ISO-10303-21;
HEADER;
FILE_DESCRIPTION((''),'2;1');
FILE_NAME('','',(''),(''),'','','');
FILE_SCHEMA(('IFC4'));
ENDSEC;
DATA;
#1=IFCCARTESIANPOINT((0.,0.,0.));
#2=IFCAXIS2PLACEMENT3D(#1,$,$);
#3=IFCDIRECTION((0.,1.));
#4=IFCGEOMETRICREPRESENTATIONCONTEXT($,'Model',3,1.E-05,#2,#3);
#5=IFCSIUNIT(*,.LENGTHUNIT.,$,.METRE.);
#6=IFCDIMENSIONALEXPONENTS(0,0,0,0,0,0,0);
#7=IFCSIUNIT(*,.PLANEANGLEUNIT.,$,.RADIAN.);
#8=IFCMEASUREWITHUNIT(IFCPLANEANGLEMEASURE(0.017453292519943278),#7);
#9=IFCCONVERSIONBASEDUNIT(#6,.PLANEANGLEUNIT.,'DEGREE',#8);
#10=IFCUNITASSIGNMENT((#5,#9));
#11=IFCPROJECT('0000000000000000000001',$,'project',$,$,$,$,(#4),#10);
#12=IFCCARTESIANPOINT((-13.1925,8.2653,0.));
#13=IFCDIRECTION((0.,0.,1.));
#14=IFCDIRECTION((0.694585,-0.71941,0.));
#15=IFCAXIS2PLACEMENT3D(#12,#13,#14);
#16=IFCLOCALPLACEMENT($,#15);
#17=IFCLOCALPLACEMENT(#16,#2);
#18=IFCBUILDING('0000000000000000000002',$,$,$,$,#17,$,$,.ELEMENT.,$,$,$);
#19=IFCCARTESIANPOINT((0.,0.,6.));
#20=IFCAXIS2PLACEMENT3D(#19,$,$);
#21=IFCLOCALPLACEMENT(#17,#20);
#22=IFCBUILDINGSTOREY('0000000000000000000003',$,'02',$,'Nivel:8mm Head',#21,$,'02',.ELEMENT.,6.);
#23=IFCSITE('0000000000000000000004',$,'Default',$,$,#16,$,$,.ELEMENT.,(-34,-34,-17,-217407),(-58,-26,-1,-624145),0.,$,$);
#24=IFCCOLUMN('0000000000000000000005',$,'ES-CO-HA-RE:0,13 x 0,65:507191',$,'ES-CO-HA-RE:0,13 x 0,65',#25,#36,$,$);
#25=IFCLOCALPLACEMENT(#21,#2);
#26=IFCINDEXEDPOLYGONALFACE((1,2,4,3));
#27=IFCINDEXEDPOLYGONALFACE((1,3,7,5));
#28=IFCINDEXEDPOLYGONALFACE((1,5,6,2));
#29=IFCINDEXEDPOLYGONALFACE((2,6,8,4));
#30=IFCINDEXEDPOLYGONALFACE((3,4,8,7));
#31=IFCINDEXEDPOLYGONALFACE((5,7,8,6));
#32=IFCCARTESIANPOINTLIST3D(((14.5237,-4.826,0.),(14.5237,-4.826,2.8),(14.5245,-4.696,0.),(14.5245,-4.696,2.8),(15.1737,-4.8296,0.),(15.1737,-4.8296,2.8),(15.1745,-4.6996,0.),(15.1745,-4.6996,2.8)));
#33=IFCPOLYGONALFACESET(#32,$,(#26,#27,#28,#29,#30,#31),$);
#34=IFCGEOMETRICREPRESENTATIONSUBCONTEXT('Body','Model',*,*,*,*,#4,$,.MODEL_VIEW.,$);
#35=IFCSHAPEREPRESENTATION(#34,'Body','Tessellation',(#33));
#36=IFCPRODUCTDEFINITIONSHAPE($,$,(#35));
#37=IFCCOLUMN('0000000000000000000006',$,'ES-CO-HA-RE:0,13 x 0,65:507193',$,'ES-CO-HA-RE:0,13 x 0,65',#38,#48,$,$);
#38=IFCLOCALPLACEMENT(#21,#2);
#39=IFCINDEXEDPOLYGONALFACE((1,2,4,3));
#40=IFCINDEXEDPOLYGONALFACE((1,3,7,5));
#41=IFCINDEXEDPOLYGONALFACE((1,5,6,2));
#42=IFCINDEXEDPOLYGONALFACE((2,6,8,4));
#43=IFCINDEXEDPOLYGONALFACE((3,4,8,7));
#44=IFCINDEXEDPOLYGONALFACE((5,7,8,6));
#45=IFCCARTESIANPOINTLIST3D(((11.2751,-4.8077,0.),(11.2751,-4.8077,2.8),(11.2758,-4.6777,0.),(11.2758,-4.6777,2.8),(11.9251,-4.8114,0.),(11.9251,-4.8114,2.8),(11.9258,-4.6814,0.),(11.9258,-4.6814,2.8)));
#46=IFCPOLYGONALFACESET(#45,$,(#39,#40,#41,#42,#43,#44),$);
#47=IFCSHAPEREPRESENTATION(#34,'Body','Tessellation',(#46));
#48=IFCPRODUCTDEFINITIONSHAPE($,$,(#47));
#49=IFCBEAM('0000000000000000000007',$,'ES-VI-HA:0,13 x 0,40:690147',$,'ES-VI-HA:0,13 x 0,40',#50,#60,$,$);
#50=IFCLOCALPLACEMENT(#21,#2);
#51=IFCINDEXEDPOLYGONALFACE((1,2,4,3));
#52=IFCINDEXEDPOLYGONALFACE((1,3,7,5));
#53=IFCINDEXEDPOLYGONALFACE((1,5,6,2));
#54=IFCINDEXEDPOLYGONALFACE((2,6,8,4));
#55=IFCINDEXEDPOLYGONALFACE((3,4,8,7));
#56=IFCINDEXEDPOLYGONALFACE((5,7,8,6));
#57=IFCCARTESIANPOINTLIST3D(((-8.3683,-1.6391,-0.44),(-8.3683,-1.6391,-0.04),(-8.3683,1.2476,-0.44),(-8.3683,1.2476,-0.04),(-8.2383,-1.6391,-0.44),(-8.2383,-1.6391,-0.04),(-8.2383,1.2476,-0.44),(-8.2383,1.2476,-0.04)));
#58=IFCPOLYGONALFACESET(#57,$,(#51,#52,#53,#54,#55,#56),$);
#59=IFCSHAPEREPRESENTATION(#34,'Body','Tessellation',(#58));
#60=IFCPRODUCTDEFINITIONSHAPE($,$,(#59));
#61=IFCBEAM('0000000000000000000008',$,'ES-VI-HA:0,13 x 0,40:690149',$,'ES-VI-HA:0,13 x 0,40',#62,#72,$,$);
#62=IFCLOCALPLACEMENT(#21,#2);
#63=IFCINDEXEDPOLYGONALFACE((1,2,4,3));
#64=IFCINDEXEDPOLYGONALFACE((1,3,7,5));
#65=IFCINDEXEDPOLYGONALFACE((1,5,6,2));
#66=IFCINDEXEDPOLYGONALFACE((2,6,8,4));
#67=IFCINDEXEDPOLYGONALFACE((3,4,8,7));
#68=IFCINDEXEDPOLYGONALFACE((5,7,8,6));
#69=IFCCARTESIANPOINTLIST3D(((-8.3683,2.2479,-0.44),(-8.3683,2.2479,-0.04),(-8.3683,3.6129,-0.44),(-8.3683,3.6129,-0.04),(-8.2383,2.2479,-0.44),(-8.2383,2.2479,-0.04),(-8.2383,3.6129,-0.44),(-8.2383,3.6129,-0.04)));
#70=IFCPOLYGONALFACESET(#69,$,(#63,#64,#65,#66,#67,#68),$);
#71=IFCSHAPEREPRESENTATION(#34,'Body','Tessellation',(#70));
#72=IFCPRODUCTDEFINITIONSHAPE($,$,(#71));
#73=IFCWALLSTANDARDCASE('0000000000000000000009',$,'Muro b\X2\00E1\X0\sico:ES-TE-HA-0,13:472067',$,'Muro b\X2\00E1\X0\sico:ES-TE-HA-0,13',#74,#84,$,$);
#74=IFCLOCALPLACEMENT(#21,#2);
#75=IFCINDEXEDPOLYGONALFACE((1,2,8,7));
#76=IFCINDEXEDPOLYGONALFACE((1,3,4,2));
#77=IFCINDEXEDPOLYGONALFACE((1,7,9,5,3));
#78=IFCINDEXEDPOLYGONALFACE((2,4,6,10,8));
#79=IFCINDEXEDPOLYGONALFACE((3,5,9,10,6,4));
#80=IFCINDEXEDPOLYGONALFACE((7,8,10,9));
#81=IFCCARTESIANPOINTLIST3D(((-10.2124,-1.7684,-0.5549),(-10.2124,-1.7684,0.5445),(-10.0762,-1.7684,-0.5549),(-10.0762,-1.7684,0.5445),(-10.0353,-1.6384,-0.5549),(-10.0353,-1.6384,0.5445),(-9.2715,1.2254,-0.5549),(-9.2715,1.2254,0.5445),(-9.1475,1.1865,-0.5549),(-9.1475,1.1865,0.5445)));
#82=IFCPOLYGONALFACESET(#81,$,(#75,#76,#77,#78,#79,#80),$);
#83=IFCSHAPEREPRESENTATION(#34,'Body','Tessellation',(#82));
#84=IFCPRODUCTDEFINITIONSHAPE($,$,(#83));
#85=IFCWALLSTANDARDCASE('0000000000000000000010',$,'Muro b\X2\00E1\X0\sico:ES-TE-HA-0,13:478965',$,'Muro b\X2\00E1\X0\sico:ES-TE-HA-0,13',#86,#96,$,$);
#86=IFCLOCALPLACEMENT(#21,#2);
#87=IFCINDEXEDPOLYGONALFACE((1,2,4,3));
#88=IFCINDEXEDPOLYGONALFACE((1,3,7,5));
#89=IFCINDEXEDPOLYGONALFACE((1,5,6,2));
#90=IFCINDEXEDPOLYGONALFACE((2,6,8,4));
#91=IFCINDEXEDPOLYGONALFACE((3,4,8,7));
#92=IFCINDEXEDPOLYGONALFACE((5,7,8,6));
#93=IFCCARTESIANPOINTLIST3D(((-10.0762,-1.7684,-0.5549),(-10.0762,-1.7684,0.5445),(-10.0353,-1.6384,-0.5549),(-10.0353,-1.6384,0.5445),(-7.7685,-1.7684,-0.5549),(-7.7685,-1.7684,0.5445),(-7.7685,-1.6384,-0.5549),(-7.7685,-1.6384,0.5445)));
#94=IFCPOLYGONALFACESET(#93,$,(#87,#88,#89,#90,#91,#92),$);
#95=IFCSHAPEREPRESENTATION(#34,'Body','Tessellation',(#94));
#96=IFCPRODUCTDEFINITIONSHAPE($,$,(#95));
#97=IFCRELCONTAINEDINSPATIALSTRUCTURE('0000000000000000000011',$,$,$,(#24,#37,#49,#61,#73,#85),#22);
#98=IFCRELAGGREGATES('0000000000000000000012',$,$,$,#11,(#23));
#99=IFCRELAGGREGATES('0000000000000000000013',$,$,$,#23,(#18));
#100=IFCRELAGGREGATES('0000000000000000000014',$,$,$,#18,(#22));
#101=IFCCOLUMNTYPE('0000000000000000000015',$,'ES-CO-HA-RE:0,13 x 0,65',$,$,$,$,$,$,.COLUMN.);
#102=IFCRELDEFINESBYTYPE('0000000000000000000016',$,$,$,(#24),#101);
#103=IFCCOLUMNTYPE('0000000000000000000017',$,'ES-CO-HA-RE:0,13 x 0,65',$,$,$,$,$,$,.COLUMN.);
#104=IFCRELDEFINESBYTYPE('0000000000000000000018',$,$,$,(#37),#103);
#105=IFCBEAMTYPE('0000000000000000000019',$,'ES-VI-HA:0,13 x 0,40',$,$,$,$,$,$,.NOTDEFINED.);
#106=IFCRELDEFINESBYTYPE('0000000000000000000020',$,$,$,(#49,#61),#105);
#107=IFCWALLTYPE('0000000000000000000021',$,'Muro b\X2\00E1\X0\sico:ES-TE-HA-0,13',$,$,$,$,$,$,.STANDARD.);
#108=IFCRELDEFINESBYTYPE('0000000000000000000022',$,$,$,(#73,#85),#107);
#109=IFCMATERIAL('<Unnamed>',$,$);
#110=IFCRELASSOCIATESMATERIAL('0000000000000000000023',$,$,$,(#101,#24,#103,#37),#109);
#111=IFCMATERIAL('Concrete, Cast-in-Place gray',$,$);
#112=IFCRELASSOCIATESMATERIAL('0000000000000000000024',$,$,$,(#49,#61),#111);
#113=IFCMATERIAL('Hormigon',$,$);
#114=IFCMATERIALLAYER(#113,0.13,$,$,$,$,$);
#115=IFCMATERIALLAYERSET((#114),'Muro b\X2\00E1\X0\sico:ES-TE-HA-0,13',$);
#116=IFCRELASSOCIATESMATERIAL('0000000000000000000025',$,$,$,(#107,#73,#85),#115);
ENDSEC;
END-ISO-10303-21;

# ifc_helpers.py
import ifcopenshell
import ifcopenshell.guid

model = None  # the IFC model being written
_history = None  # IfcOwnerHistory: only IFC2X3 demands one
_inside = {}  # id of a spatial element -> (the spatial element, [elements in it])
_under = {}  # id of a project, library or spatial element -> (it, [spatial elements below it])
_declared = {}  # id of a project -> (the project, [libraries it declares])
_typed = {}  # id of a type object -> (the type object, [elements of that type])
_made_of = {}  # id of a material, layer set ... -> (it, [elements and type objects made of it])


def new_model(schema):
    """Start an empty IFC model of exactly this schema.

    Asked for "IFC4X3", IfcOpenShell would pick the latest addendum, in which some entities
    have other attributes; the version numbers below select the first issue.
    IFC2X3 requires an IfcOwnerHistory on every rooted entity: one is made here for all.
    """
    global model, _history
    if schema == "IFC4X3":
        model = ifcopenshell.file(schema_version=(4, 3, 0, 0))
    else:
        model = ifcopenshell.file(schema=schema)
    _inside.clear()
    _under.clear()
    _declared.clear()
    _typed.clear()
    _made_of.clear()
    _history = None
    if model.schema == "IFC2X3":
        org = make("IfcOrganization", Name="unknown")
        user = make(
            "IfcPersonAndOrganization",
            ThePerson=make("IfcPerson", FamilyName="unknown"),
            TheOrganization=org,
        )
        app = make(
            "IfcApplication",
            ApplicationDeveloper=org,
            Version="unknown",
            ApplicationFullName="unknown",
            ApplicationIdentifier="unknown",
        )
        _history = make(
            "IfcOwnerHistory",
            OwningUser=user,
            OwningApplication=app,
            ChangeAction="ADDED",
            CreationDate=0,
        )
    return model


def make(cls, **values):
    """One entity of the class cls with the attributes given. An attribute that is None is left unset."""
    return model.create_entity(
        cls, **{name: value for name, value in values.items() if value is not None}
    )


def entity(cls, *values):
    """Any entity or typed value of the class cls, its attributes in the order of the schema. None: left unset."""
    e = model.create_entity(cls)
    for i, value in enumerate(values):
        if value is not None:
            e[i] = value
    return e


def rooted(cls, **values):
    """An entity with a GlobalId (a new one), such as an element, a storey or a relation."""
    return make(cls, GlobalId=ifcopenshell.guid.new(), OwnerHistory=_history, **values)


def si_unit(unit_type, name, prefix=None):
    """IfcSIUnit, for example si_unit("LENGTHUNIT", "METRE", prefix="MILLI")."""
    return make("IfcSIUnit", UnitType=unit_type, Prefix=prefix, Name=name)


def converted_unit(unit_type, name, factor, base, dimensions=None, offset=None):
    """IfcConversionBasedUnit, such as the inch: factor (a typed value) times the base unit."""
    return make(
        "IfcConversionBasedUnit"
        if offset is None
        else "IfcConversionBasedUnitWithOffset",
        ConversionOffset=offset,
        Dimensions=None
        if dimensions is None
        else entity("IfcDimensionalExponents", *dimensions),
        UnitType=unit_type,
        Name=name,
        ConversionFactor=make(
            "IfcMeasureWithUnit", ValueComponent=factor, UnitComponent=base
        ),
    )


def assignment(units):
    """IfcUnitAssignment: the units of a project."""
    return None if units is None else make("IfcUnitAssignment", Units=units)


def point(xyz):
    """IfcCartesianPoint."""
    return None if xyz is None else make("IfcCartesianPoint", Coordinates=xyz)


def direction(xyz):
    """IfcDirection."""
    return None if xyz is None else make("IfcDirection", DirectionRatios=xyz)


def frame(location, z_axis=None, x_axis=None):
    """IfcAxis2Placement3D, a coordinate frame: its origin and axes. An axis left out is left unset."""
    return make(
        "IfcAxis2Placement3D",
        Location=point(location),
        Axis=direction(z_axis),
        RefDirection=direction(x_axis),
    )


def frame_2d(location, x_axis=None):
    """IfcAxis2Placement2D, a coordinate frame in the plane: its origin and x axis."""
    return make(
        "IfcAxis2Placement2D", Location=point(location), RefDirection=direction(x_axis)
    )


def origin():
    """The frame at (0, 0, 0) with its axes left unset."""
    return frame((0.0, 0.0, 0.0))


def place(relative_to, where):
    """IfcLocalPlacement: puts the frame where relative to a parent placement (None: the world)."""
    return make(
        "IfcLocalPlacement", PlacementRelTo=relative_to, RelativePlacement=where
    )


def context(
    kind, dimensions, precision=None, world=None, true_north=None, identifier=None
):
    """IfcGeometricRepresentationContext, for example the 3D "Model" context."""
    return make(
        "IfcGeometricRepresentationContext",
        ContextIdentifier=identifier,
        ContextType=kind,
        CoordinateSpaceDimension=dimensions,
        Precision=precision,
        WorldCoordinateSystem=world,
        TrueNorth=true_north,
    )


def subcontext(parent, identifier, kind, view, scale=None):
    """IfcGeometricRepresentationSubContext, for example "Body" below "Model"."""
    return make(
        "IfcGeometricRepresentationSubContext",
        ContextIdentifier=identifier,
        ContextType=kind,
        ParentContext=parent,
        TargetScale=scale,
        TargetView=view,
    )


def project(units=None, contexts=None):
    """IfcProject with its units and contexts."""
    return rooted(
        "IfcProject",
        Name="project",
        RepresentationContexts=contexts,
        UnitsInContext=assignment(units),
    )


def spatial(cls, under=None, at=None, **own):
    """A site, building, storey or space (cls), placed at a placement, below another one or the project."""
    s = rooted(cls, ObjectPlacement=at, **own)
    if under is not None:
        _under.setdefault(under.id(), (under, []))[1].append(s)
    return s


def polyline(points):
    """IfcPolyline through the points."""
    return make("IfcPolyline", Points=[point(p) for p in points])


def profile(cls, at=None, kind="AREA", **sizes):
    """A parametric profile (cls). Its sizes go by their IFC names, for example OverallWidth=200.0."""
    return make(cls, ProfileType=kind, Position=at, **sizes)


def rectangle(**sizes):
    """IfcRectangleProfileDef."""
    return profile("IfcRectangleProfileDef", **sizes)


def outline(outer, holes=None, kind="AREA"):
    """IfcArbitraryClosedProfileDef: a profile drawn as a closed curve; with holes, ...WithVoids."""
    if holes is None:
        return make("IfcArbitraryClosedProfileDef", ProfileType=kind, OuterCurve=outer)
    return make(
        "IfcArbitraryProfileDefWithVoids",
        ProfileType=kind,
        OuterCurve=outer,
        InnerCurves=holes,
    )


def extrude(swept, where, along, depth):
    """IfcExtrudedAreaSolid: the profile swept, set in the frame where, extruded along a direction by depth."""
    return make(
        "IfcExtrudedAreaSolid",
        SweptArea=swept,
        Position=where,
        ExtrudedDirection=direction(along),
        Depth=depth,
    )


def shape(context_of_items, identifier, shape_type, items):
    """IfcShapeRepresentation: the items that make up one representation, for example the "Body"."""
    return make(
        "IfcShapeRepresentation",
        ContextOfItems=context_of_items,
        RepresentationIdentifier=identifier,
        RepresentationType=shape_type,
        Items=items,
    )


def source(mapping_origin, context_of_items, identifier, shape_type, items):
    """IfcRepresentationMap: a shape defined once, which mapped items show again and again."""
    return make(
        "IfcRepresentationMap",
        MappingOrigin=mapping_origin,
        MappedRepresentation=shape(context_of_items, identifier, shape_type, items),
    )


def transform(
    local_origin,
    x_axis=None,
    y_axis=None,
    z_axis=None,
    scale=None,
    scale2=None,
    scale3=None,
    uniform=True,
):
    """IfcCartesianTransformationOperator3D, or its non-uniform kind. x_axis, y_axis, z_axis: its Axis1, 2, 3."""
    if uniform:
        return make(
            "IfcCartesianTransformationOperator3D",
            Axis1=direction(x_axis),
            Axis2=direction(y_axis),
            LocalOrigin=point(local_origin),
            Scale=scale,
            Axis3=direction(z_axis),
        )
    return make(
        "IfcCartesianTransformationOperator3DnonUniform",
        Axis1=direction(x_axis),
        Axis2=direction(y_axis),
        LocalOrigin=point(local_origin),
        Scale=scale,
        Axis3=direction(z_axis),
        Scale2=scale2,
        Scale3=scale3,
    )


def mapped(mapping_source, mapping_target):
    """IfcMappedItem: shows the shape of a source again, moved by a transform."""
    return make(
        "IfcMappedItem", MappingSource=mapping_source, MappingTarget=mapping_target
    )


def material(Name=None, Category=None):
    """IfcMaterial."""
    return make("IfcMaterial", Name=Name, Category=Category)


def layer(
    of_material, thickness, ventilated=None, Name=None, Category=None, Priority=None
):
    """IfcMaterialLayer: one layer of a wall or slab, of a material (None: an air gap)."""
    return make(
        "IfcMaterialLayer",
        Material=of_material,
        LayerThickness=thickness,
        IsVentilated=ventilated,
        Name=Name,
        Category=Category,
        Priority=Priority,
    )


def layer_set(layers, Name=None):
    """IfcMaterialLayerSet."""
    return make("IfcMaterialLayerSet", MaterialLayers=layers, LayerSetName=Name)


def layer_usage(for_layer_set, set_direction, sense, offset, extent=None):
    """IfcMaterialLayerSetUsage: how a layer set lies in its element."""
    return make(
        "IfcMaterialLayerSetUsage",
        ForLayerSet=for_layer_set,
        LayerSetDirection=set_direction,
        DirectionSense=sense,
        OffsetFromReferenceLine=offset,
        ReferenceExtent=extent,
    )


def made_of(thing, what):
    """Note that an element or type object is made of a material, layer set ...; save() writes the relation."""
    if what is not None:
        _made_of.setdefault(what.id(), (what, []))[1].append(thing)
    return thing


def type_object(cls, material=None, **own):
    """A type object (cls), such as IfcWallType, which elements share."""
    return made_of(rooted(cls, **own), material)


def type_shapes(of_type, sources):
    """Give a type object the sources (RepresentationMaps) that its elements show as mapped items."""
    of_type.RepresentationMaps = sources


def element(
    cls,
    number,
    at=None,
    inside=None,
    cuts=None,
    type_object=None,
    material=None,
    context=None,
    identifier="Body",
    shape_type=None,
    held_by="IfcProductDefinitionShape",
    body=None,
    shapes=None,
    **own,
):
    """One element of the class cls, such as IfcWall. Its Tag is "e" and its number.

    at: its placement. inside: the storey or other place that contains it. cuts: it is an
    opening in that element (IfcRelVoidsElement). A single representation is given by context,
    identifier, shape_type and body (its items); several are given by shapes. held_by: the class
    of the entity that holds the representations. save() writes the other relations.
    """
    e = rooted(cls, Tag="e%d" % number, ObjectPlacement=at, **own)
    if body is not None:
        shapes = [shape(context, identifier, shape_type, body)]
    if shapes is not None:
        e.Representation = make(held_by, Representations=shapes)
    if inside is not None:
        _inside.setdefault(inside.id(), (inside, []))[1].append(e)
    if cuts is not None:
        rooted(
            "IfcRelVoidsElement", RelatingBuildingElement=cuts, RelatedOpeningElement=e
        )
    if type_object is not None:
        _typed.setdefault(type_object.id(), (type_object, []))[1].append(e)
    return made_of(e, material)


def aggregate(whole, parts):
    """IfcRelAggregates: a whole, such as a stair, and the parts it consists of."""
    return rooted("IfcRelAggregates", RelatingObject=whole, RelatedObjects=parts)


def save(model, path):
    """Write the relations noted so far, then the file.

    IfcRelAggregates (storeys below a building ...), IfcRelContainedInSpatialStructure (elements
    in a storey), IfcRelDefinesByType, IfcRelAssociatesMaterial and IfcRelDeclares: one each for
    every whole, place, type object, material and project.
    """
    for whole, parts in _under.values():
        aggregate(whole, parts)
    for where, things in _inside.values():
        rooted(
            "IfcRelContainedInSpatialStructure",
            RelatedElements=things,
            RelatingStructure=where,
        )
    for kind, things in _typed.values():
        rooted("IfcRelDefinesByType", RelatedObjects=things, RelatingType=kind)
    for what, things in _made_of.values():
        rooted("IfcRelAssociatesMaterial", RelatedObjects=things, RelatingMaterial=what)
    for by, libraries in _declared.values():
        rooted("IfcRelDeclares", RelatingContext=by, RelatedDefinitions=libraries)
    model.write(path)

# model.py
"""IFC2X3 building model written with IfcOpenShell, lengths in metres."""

from ifc_helpers import new_model, entity, si_unit, converted_unit, direction, frame, frame_2d, origin, place, context, subcontext, project, spatial, polyline, rectangle, outline, extrude, source, transform, mapped, material, layer, layer_set, layer_usage, type_object, type_shapes, element, save


model = new_model("IFC2X3")

# Units and contexts
model_context = context("Model", 3, precision=1e-05, world=origin(), true_north=direction((0.0, 1.0)))
body_context = subcontext(model_context, "Body", "Model", "MODEL_VIEW")
ifc_project = project(units=[si_unit("LENGTHUNIT", "METRE"), converted_unit("PLANEANGLEUNIT", "DEGREE", entity("IfcPlaneAngleMeasure", 0.017453292519943278), si_unit("PLANEANGLEUNIT", "RADIAN"), dimensions=[0, 0, 0, 0, 0, 0, 0])], contexts=[model_context])

# Site, building, storey
site_placement = place(None, frame((-13.1925, 8.2653, 0.0), z_axis=(0.0, 0.0, 1.0), x_axis=(0.694585, -0.71941, 0.0)))
site = spatial("IfcSite", under=ifc_project, at=site_placement, Name="Default", CompositionType="ELEMENT", RefLatitude=(-34, -34, -17, -217407), RefLongitude=(-58, -26, -1, -624145), RefElevation=0.0)
building_placement = place(site_placement, origin())
building = spatial("IfcBuilding", under=site, at=building_placement, CompositionType="ELEMENT")
storey_placement = place(building_placement, frame((0.0, 0.0, 6.0)))
storey = spatial("IfcBuildingStorey", under=building, at=storey_placement, Name="02", ObjectType="Nivel:8mm Head", LongName="02", CompositionType="ELEMENT", Elevation=6.0)

# Columns
ifc_material_1 = material(Name="<Unnamed>")
column_type_1 = type_object("IfcColumnType", Name="ES-CO-HA-RE:0,13 x 0,65", PredefinedType="COLUMN", material=ifc_material_1)
shared_shape_1 = source(origin(), body_context, "Body", "SweptSolid", [
    extrude(rectangle(XDim=0.65, YDim=0.13, at=frame_2d((0.0, 0.0), x_axis=(1.0, 0.0))), frame((14.8491, -4.7628, 6.0), z_axis=(0.0, 0.0, 1.0), x_axis=(-0.999984, 0.005619, 0.0)), (0.0, 0.0, 1.0), 2.8),
])
type_shapes(column_type_1, [shared_shape_1])
column_1_placement = place(storey_placement, frame((0.0, 0.0, -6.0)))
element("IfcColumn", 1, at=column_1_placement, inside=storey, type_object=column_type_1, material=ifc_material_1, Name="ES-CO-HA-RE:0,13 x 0,65:507191", ObjectType="ES-CO-HA-RE:0,13 x 0,65", context=body_context, shape_type="MappedRepresentation", body=[
    mapped(shared_shape_1, transform((0.0, 0.0, 0.0), scale=1.0)),
])
column_type_2 = type_object("IfcColumnType", Name="ES-CO-HA-RE:0,13 x 0,65", PredefinedType="COLUMN", material=ifc_material_1)
shared_shape_2 = source(origin(), body_context, "Body", "SweptSolid", [
    extrude(rectangle(XDim=0.65, YDim=0.13, at=frame_2d((0.0, 0.0), x_axis=(1.0, 0.0))), frame((11.6005, -4.7445, 6.0), z_axis=(0.0, 0.0, 1.0), x_axis=(-0.999984, 0.005619, 0.0)), (0.0, 0.0, 1.0), 2.8),
])
type_shapes(column_type_2, [shared_shape_2])
column_2_placement = place(storey_placement, frame((0.0, 0.0, -6.0)))
element("IfcColumn", 2, at=column_2_placement, inside=storey, type_object=column_type_2, material=ifc_material_1, Name="ES-CO-HA-RE:0,13 x 0,65:507193", ObjectType="ES-CO-HA-RE:0,13 x 0,65", context=body_context, shape_type="MappedRepresentation", body=[
    mapped(shared_shape_2, transform((0.0, 0.0, 0.0), scale=1.0)),
])

# Beams
ifc_material_2 = material(Name="Concrete, Cast-in-Place gray")
beam_type = type_object("IfcBeamType", Name="ES-VI-HA:0,13 x 0,40", PredefinedType="NOTDEFINED")
beam_1_placement = place(storey_placement, frame((-8.3033, -1.6391, -0.04), z_axis=(0.0, 0.0, 1.0), x_axis=(0.0, 1.0, 0.0)))
element("IfcBeam", 3, at=beam_1_placement, inside=storey, type_object=beam_type, material=ifc_material_2, Name="ES-VI-HA:0,13 x 0,40:690147", ObjectType="ES-VI-HA:0,13 x 0,40", context=body_context, shape_type="SweptSolid", body=[
    extrude(rectangle(XDim=0.4, YDim=0.13, at=frame_2d((0.0, 0.0), x_axis=(1.0, 0.0))), frame((0.0, 0.0, -0.2), z_axis=(1.0, 0.0, 0.0), x_axis=(0.0, 0.0, -1.0)), (0.0, 0.0, 1.0), 2.8867),
])
beam_2_placement = place(storey_placement, frame((-8.3033, 2.2479, -0.04), z_axis=(0.0, 0.0, 1.0), x_axis=(0.0, 1.0, 0.0)))
element("IfcBeam", 4, at=beam_2_placement, inside=storey, type_object=beam_type, material=ifc_material_2, Name="ES-VI-HA:0,13 x 0,40:690149", ObjectType="ES-VI-HA:0,13 x 0,40", context=body_context, shape_type="SweptSolid", body=[
    extrude(rectangle(XDim=0.4, YDim=0.13, at=frame_2d((0.0, 0.0), x_axis=(1.0, 0.0))), frame((0.0, 0.0, -0.2), z_axis=(1.0, 0.0, 0.0), x_axis=(0.0, 0.0, -1.0)), (0.0, 0.0, 1.0), 1.365),
])

# Shared definitions
ifc_material_3 = material(Name="Hormigon")

# Walls
ifc_layer_1 = layer(ifc_material_3, 0.13)
ifc_layer_set_1 = layer_set([ifc_layer_1], Name="Muro básico:ES-TE-HA-0,13")
ifc_layer_usage_1 = layer_usage(ifc_layer_set_1, "AXIS2", "NEGATIVE", 0.065)
wall_type = type_object("IfcWallType", Name="Muro básico:ES-TE-HA-0,13", PredefinedType="STANDARD", material=ifc_layer_set_1)
wall_1_placement = place(storey_placement, frame((-10.1504, -1.7879, -0.5549), z_axis=(0.0, 0.0, 1.0), x_axis=(0.299835, 0.953991, 0.0)))
element("IfcWallStandardCase", 5, at=wall_1_placement, inside=storey, type_object=wall_type, material=ifc_layer_usage_1, Name="Muro básico:ES-TE-HA-0,13:472067", ObjectType="Muro básico:ES-TE-HA-0,13", context=body_context, shape_type="SweptSolid", body=[
    extrude(outline(polyline([(3.1382, -0.065), (3.1382, 0.065), (0.0, 0.065), (0.0409, -0.065), (0.1771, -0.065), (3.1382, -0.065)])), origin(), (0.0, 0.0, 1.0), 1.0993),
])
ifc_layer_usage_2 = layer_usage(ifc_layer_set_1, "AXIS2", "POSITIVE", -0.065)
wall_2_placement = place(storey_placement, frame((-10.0762, -1.7034, -0.5549)))
element("IfcWallStandardCase", 6, at=wall_2_placement, inside=storey, type_object=wall_type, material=ifc_layer_usage_2, Name="Muro básico:ES-TE-HA-0,13:478965", ObjectType="Muro básico:ES-TE-HA-0,13", context=body_context, shape_type="SweptSolid", body=[
    extrude(outline(polyline([(2.3077, -0.065), (2.3077, 0.065), (0.0409, 0.065), (0.0, -0.065), (2.3077, -0.065)])), origin(), (0.0, 0.0, 1.0), 1.0993),
])

save(model, "model.ifc")
